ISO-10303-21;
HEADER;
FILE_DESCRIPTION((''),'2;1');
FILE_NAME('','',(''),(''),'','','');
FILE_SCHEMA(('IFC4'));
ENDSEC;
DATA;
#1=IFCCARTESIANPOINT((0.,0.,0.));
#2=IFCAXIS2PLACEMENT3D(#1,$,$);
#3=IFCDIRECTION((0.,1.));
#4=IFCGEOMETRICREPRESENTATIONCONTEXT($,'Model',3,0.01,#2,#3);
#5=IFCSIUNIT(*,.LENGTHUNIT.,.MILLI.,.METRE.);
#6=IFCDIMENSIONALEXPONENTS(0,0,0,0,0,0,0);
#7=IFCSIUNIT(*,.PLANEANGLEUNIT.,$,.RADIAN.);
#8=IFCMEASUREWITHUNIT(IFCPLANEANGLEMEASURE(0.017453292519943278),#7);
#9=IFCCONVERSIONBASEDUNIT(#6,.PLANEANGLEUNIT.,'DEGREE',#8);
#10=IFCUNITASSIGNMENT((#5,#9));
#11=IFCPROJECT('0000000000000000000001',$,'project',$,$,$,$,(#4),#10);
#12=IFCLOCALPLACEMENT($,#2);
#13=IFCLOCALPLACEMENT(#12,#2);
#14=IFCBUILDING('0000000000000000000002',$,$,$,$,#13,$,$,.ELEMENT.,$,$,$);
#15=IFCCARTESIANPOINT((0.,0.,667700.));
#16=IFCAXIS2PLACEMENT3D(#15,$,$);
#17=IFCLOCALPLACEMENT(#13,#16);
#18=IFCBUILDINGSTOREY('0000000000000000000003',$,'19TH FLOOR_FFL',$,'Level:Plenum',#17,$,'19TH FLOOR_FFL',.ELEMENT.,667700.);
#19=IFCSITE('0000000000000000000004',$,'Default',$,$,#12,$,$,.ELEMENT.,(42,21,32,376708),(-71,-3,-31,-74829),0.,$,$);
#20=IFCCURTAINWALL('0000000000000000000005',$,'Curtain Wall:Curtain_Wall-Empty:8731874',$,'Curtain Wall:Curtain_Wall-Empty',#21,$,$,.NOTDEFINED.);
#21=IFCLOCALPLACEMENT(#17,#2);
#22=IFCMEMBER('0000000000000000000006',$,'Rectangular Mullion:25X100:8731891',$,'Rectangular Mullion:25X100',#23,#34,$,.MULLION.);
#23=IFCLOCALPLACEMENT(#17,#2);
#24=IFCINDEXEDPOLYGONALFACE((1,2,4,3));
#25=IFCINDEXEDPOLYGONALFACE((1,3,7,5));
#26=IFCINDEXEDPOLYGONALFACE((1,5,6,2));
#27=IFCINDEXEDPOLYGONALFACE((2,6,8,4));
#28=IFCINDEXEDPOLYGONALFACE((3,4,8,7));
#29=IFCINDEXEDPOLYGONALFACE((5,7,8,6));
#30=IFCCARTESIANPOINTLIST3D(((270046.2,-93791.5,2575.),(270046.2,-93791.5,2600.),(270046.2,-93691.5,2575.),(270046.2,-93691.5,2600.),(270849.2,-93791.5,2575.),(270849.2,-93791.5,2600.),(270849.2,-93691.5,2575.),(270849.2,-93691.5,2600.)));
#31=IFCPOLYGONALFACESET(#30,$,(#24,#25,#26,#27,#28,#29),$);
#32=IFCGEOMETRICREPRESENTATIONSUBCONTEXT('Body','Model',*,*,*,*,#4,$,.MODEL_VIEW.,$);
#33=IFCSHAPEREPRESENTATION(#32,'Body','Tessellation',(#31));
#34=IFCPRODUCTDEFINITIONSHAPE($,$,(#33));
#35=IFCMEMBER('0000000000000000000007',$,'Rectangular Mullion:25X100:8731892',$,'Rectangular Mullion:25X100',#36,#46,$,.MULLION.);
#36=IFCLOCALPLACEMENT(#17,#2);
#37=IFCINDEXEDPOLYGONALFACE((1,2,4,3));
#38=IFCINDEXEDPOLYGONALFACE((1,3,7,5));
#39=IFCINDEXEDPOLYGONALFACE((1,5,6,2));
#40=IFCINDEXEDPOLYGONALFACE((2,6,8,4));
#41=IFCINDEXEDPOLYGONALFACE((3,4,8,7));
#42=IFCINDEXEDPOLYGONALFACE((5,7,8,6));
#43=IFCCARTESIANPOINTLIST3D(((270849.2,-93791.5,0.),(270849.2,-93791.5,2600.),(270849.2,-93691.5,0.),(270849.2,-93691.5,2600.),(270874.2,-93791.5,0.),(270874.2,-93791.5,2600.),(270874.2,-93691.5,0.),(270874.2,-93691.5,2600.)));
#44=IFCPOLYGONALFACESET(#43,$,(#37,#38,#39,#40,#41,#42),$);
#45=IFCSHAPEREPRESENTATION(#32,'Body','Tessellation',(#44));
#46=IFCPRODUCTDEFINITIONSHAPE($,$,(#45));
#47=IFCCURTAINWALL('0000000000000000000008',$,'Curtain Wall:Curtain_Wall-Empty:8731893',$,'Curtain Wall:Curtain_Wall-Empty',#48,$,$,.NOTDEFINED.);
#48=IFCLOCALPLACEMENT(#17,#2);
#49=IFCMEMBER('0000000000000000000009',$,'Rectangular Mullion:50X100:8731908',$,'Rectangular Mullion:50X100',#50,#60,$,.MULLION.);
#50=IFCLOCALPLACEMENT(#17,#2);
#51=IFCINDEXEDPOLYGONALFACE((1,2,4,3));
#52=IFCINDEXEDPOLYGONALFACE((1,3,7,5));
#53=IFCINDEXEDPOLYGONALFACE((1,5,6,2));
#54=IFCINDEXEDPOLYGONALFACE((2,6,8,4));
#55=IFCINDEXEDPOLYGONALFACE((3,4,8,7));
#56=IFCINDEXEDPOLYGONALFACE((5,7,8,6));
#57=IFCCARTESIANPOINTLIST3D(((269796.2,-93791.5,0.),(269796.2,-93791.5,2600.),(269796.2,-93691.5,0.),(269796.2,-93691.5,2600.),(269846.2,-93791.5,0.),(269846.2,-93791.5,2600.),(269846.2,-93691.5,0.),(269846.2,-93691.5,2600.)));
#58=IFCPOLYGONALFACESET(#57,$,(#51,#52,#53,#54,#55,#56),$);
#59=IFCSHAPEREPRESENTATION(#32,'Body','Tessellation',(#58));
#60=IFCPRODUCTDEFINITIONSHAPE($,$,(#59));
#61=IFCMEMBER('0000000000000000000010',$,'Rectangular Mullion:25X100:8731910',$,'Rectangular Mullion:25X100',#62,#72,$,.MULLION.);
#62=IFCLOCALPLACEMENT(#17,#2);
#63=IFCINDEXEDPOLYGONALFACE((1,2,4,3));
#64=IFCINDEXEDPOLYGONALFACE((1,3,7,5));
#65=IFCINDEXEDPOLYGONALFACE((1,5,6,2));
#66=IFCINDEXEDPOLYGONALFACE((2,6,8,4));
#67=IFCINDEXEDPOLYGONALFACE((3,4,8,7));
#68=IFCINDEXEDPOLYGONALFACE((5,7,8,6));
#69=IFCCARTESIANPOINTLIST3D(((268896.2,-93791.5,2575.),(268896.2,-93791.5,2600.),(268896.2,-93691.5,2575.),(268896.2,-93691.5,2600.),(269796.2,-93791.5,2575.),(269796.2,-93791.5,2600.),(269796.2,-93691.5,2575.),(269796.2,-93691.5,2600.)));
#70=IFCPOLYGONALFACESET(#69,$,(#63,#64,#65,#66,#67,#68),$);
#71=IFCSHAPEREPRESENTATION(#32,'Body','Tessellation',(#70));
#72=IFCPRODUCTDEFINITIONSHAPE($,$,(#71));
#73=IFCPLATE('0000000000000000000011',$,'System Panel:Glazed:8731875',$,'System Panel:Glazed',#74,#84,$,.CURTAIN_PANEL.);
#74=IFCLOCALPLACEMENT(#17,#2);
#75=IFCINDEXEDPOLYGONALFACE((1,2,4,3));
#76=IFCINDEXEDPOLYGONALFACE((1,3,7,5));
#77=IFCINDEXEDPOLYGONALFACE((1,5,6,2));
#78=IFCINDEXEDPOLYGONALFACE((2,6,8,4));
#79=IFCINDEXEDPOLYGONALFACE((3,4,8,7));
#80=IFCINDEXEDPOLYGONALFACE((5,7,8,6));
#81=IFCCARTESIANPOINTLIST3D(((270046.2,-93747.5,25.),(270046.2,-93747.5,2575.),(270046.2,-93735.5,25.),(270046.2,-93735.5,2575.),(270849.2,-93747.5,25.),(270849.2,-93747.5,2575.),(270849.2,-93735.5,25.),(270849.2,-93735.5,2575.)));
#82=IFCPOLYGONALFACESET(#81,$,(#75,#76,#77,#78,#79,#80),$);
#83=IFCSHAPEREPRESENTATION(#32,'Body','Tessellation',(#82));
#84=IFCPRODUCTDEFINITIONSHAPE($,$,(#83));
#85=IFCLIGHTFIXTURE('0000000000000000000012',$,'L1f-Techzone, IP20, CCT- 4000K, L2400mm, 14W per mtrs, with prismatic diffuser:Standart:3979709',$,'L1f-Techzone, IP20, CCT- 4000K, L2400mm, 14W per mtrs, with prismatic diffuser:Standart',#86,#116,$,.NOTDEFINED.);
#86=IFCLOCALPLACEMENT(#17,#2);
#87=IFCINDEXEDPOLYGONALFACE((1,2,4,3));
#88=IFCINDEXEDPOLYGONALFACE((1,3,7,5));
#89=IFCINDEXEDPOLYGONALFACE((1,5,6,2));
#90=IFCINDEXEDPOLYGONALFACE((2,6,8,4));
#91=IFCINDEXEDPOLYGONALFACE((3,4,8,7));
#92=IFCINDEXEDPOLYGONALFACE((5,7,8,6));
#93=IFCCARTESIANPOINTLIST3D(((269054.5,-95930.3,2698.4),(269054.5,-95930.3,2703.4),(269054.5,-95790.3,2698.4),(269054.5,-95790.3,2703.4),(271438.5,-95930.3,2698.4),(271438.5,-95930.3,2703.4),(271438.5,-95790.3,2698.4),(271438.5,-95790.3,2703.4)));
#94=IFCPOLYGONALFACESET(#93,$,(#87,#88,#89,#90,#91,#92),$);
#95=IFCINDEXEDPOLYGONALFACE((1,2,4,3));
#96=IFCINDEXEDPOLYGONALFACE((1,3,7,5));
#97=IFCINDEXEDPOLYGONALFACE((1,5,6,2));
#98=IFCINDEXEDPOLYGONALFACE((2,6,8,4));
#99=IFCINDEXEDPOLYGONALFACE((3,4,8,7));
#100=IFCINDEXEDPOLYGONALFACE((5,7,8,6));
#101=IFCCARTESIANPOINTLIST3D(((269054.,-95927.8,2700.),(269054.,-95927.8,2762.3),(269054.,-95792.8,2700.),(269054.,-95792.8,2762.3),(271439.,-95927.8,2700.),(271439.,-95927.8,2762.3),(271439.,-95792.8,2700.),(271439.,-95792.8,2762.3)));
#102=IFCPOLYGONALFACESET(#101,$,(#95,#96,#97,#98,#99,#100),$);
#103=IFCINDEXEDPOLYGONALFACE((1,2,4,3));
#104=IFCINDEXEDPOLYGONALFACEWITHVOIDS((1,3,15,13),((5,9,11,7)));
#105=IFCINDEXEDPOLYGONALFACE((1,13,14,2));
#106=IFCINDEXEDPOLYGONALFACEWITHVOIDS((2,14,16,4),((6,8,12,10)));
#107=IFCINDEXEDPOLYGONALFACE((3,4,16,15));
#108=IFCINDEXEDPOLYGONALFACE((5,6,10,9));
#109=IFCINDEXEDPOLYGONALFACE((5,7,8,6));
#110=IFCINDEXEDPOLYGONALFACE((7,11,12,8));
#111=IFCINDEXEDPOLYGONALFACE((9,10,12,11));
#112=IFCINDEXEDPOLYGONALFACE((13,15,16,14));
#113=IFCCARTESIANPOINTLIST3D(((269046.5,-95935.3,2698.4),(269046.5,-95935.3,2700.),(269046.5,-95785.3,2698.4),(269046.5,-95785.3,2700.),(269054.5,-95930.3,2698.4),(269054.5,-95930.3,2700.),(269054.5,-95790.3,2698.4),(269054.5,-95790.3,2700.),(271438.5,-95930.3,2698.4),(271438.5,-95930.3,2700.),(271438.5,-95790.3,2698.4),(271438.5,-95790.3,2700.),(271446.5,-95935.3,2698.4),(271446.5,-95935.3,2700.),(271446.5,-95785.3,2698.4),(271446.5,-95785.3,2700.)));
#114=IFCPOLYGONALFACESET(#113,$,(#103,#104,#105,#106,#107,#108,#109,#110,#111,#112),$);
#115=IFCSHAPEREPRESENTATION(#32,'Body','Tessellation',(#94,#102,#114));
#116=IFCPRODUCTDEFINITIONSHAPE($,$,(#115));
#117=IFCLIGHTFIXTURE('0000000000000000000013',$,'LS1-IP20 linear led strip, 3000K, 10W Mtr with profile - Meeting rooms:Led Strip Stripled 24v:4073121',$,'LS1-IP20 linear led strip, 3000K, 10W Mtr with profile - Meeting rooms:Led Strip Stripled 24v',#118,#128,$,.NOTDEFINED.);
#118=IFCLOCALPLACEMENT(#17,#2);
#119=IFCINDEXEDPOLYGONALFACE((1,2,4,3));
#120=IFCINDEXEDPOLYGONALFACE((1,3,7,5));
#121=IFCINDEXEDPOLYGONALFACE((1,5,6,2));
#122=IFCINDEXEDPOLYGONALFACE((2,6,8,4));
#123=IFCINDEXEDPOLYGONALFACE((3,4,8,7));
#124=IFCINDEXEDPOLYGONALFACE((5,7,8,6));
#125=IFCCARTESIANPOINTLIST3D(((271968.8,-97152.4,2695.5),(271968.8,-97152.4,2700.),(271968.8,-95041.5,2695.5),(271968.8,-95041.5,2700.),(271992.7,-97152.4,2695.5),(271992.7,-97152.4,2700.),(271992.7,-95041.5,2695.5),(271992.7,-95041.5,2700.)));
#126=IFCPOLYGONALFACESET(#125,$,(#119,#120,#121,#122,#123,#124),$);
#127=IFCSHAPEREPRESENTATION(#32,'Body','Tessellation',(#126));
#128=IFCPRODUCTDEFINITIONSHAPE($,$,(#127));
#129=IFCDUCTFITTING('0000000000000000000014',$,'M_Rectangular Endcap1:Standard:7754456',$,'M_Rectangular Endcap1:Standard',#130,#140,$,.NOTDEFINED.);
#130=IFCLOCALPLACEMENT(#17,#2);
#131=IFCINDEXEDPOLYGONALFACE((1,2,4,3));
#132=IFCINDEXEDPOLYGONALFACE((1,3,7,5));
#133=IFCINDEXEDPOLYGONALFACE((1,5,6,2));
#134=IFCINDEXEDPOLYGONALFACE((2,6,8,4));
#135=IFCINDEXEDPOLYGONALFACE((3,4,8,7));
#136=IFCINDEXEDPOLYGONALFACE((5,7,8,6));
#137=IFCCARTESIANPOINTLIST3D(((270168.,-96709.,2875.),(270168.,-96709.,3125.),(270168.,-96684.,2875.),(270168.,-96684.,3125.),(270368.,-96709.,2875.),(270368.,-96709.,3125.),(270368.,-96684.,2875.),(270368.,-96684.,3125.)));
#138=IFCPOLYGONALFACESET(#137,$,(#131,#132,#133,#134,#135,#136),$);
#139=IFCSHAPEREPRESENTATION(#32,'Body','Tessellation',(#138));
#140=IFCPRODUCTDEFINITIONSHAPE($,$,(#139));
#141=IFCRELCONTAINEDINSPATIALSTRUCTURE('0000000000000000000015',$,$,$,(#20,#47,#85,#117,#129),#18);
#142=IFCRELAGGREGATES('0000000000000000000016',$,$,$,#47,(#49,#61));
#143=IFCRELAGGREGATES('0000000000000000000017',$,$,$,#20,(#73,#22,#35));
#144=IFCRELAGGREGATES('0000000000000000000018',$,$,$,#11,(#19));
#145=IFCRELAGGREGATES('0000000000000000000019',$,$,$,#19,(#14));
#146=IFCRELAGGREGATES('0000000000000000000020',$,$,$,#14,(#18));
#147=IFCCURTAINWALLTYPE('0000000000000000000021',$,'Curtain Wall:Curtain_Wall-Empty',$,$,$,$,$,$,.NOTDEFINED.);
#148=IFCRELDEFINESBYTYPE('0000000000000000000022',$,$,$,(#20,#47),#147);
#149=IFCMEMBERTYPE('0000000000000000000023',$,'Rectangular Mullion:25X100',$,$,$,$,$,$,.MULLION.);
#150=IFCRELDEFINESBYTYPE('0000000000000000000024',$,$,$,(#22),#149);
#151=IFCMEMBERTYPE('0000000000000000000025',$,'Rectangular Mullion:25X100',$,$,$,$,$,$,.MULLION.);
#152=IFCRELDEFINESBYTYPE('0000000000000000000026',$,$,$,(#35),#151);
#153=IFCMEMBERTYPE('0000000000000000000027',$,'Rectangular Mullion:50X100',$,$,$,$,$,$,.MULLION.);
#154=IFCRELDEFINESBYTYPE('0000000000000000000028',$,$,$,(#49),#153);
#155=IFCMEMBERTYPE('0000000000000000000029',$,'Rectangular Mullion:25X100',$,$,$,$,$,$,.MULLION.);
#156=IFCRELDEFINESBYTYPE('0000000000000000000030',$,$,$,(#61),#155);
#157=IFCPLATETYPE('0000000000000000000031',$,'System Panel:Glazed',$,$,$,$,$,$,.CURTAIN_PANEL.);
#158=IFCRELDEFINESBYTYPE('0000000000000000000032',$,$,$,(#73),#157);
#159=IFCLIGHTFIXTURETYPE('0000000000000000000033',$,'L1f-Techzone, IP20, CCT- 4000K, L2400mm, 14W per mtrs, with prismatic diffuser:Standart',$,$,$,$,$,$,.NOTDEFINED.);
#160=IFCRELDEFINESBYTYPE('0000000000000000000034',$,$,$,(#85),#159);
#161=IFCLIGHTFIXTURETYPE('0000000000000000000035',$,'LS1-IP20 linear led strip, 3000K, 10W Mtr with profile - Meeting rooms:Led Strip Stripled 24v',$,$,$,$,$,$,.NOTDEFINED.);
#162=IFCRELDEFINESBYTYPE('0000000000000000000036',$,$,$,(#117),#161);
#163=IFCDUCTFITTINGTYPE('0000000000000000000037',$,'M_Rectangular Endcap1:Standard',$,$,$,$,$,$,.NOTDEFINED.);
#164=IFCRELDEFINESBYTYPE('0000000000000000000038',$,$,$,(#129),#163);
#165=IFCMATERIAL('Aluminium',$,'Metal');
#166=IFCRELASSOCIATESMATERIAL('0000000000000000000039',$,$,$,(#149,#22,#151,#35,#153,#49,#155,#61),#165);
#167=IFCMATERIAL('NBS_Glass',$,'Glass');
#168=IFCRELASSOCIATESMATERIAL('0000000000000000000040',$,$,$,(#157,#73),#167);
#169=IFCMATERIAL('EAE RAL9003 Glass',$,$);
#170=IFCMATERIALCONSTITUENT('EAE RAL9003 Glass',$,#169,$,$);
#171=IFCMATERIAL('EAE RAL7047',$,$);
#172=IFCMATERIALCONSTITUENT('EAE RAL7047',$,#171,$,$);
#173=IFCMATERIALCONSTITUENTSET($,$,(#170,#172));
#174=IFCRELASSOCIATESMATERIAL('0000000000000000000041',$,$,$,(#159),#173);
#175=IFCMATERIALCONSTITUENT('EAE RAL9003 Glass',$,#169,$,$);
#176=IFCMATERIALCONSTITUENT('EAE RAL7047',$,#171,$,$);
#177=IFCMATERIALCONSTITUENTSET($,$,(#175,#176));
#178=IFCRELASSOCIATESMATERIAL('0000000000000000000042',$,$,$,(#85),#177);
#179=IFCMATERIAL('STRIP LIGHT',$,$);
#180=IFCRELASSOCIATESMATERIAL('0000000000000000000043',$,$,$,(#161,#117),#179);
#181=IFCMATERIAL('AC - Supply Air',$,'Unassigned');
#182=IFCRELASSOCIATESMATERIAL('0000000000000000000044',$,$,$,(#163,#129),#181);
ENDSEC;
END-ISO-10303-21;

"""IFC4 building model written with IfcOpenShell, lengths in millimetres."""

from ifc_helpers import new_model, entity, si_unit, converted_unit, direction, frame, origin, place, context, subcontext, project, spatial, indexed_curve, outline, extrude, source, transform, mapped, material, constituent, constituent_set, type_object, type_shapes, element, aggregate, save


model = new_model("IFC4")

# Units and contexts
model_context = context("Model", 3, precision=0.01, world=origin(), true_north=direction((0.0, 1.0)))
body_context = subcontext(model_context, "Body", "Model", "MODEL_VIEW")
ifc_project = project(units=[si_unit("LENGTHUNIT", "METRE", prefix="MILLI"), converted_unit("PLANEANGLEUNIT", "DEGREE", entity("IfcPlaneAngleMeasure", 0.017453292519943278), si_unit("PLANEANGLEUNIT", "RADIAN"), dimensions=[0, 0, 0, 0, 0, 0, 0])], contexts=[model_context])

# Site, building, storey
site_placement = place(None, origin())
site = spatial("IfcSite", under=ifc_project, at=site_placement, Name="Default", CompositionType="ELEMENT", RefLatitude=(42, 21, 32, 376708), RefLongitude=(-71, -3, -31, -74829), RefElevation=0.0)
building_placement = place(site_placement, origin())
building = spatial("IfcBuilding", under=site, at=building_placement, CompositionType="ELEMENT")
storey_placement = place(building_placement, frame((0.0, 0.0, 667700.0)))
storey = spatial("IfcBuildingStorey", under=building, at=storey_placement, Name="19TH FLOOR_FFL", ObjectType="Level:Plenum", LongName="19TH FLOOR_FFL", CompositionType="ELEMENT", Elevation=667700.0)

# Curtain walls, members
curtain_wall_type = type_object("IfcCurtainWallType", Name="Curtain Wall:Curtain_Wall-Empty", PredefinedType="NOTDEFINED")
curtain_wall_1_placement = place(storey_placement, frame((0.0, 0.0, -667700.0)))
curtain_wall_1 = element("IfcCurtainWall", 1, at=curtain_wall_1_placement, inside=storey, type_object=curtain_wall_type, Name="Curtain Wall:Curtain_Wall-Empty:8731874", ObjectType="Curtain Wall:Curtain_Wall-Empty", PredefinedType="NOTDEFINED")
ifc_material_1 = material(Name="Aluminium", Category="Metal")
member_type_1 = type_object("IfcMemberType", Name="Rectangular Mullion:25X100", PredefinedType="MULLION", material=ifc_material_1)
shared_shape_1 = source(origin(), body_context, "Body", "SweptSolid", [
    extrude(outline(indexed_curve([(-12.5, -50.0), (12.5, -50.0), (12.5, 50.0), (-12.5, 50.0), (-12.5, -50.0)], self_intersect=False)), frame((-12.5, 0.0, -803.0), z_axis=(0.0, 0.0, 1.0), x_axis=(-1.0, 0.0, 0.0)), (0.0, 0.0, 1.0), 803.0),
])
type_shapes(member_type_1, [shared_shape_1])
member_1_placement = place(curtain_wall_1_placement, frame((270046.2, -93741.5, 670300.0), z_axis=(-1.0, 0.0, 0.0), x_axis=(0.0, 0.0, 1.0)))
member_1 = element("IfcMember", 2, at=member_1_placement, type_object=member_type_1, material=ifc_material_1, Name="Rectangular Mullion:25X100:8731891", ObjectType="Rectangular Mullion:25X100", PredefinedType="MULLION", context=body_context, shape_type="MappedRepresentation", body=[
    mapped(shared_shape_1, transform((0.0, 0.0, 0.0), scale=1.0)),
])
member_type_2 = type_object("IfcMemberType", Name="Rectangular Mullion:25X100", PredefinedType="MULLION", material=ifc_material_1)
shared_shape_2 = source(origin(), body_context, "Body", "SweptSolid", [
    extrude(outline(indexed_curve([(-12.5, -50.0), (12.5, -50.0), (12.5, 50.0), (-12.5, 50.0), (-12.5, -50.0)], self_intersect=False)), frame((-12.5, 0.0, -2600.0), z_axis=(0.0, 0.0, 1.0), x_axis=(-1.0, 0.0, 0.0)), (0.0, 0.0, 1.0), 2600.0),
])
type_shapes(member_type_2, [shared_shape_2])
member_2_placement = place(curtain_wall_1_placement, frame((270874.2, -93741.5, 670300.0)))
member_2 = element("IfcMember", 3, at=member_2_placement, type_object=member_type_2, material=ifc_material_1, Name="Rectangular Mullion:25X100:8731892", ObjectType="Rectangular Mullion:25X100", PredefinedType="MULLION", context=body_context, shape_type="MappedRepresentation", body=[
    mapped(shared_shape_2, transform((0.0, 0.0, 0.0), scale=1.0)),
])
curtain_wall_2_placement = place(storey_placement, frame((0.0, 0.0, -667700.0)))
curtain_wall_2 = element("IfcCurtainWall", 4, at=curtain_wall_2_placement, inside=storey, type_object=curtain_wall_type, Name="Curtain Wall:Curtain_Wall-Empty:8731893", ObjectType="Curtain Wall:Curtain_Wall-Empty", PredefinedType="NOTDEFINED")
member_type_3 = type_object("IfcMemberType", Name="Rectangular Mullion:50X100", PredefinedType="MULLION", material=ifc_material_1)
shared_shape_3 = source(origin(), body_context, "Body", "SweptSolid", [
    extrude(outline(indexed_curve([(-25.0, -50.0), (25.0, -50.0), (25.0, 50.0), (-25.0, 50.0), (-25.0, -50.0)], self_intersect=False)), frame((-25.0, 0.0, -2600.0), z_axis=(0.0, 0.0, 1.0), x_axis=(-1.0, 0.0, 0.0)), (0.0, 0.0, 1.0), 2600.0),
])
type_shapes(member_type_3, [shared_shape_3])
member_3_placement = place(curtain_wall_2_placement, frame((269846.2, -93741.5, 670300.0)))
member_3 = element("IfcMember", 5, at=member_3_placement, type_object=member_type_3, material=ifc_material_1, Name="Rectangular Mullion:50X100:8731908", ObjectType="Rectangular Mullion:50X100", PredefinedType="MULLION", context=body_context, shape_type="MappedRepresentation", body=[
    mapped(shared_shape_3, transform((0.0, 0.0, 0.0), scale=1.0)),
])
member_type_4 = type_object("IfcMemberType", Name="Rectangular Mullion:25X100", PredefinedType="MULLION", material=ifc_material_1)
shared_shape_4 = source(origin(), body_context, "Body", "SweptSolid", [
    extrude(outline(indexed_curve([(-12.5, -50.0), (12.5, -50.0), (12.5, 50.0), (-12.5, 50.0), (-12.5, -50.0)], self_intersect=False)), frame((-12.5, 0.0, -900.0), z_axis=(0.0, 0.0, 1.0), x_axis=(-1.0, 0.0, 0.0)), (0.0, 0.0, 1.0), 900.0),
])
type_shapes(member_type_4, [shared_shape_4])
member_4_placement = place(curtain_wall_2_placement, frame((268896.2, -93741.5, 670300.0), z_axis=(-1.0, 0.0, 0.0), x_axis=(0.0, 0.0, 1.0)))
member_4 = element("IfcMember", 6, at=member_4_placement, type_object=member_type_4, material=ifc_material_1, Name="Rectangular Mullion:25X100:8731910", ObjectType="Rectangular Mullion:25X100", PredefinedType="MULLION", context=body_context, shape_type="MappedRepresentation", body=[
    mapped(shared_shape_4, transform((0.0, 0.0, 0.0), scale=1.0)),
])
aggregate(curtain_wall_2, [member_3, member_4])

# Plate
ifc_material_2 = material(Name="NBS_Glass", Category="Glass")
plate_type = type_object("IfcPlateType", Name="System Panel:Glazed", PredefinedType="CURTAIN_PANEL", material=ifc_material_2)
shared_shape_5 = source(origin(), body_context, "Body", "SweptSolid", [
    extrude(outline(indexed_curve([(-6.0, -401.5), (6.0, -401.5), (6.0, 401.5), (-6.0, 401.5), (-6.0, -401.5)], self_intersect=False)), frame((0.0, 0.0, 0.0), z_axis=(0.0, 0.0, 1.0), x_axis=(0.0, 1.0, 0.0)), (0.0, 0.0, 1.0), 2550.0),
])
type_shapes(plate_type, [shared_shape_5])
plate_placement = place(curtain_wall_1_placement, frame((270447.7, -93741.5, 667725.0), z_axis=(0.0, 0.0, 1.0), x_axis=(-1.0, 0.0, 0.0)))
plate = element("IfcPlate", 7, at=plate_placement, type_object=plate_type, material=ifc_material_2, Name="System Panel:Glazed:8731875", ObjectType="System Panel:Glazed", PredefinedType="CURTAIN_PANEL", context=body_context, shape_type="MappedRepresentation", body=[
    mapped(shared_shape_5, transform((0.0, 0.0, 0.0), scale=1.0)),
])
aggregate(curtain_wall_1, [plate, member_1, member_2])

# Light fixtures
ifc_material_3 = material(Name="EAE RAL9003 Glass")
ifc_constituent_1 = constituent(ifc_material_3, Name="EAE RAL9003 Glass")
ifc_material_4 = material(Name="EAE RAL7047")
ifc_constituent_2 = constituent(ifc_material_4, Name="EAE RAL7047")
ifc_constituent_set_1 = constituent_set(constituents=[ifc_constituent_1, ifc_constituent_2])
ifc_constituent_3 = constituent(ifc_material_3, Name="EAE RAL9003 Glass")
ifc_constituent_4 = constituent(ifc_material_4, Name="EAE RAL7047")
ifc_constituent_set_2 = constituent_set(constituents=[ifc_constituent_3, ifc_constituent_4])
light_fixture_type_1 = type_object("IfcLightFixtureType", Name="L1f-Techzone, IP20, CCT- 4000K, L2400mm, 14W per mtrs, with prismatic diffuser:Standart", PredefinedType="NOTDEFINED", material=ifc_constituent_set_2)
shared_shape_6 = source(origin(), body_context, "Body", "SweptSolid", [
    extrude(outline(indexed_curve([(-70.0, -1192.0), (70.0, -1192.0), (70.0, 1192.0), (-70.0, 1192.0), (-70.0, -1192.0)], self_intersect=False)), frame((0.0, 0.0, -3.4), z_axis=(0.0, 0.0, 1.0), x_axis=(-1.0, 0.0, 0.0)), (0.0, 0.0, 1.0), 5.0),
    extrude(outline(indexed_curve([(-67.5, -1192.5), (67.5, -1192.5), (67.5, 1192.5), (-67.5, 1192.5), (-67.5, -1192.5)], self_intersect=False)), frame((0.0, 0.0, -62.3), z_axis=(0.0, 0.0, 1.0), x_axis=(-1.0, 0.0, 0.0)), (0.0, 0.0, 1.0), 62.3),
    extrude(outline(indexed_curve([(-75.0, -1200.0), (75.0, -1200.0), (75.0, 1200.0), (-75.0, 1200.0), (-75.0, -1200.0)], self_intersect=False), holes=[indexed_curve([(-70.0, -1192.0), (-70.0, 1192.0), (70.0, 1192.0), (70.0, -1192.0), (-70.0, -1192.0)], self_intersect=False)]), frame((0.0, 0.0, 0.0), z_axis=(0.0, 0.0, 1.0), x_axis=(-1.0, 0.0, 0.0)), (0.0, 0.0, 1.0), 1.6),
])
type_shapes(light_fixture_type_1, [shared_shape_6])
light_fixture_1_placement = place(storey_placement, frame((270246.5, -95860.3, 2700.0), z_axis=(0.0, 0.0, -1.0), x_axis=(0.0, 1.0, 0.0)))
element("IfcLightFixture", 8, at=light_fixture_1_placement, inside=storey, type_object=light_fixture_type_1, material=ifc_constituent_set_1, Name="L1f-Techzone, IP20, CCT- 4000K, L2400mm, 14W per mtrs, with prismatic diffuser:Standart:3979709", ObjectType="L1f-Techzone, IP20, CCT- 4000K, L2400mm, 14W per mtrs, with prismatic diffuser:Standart", PredefinedType="NOTDEFINED", context=body_context, shape_type="MappedRepresentation", body=[
    mapped(shared_shape_6, transform((0.0, 0.0, 0.0), scale=1.0)),
])
ifc_material_5 = material(Name="STRIP LIGHT")
light_fixture_type_2 = type_object("IfcLightFixtureType", Name="LS1-IP20 linear led strip, 3000K, 10W Mtr with profile - Meeting rooms:Led Strip Stripled 24v", PredefinedType="NOTDEFINED", material=ifc_material_5)
shared_shape_7 = source(origin(), body_context, "Body", "SweptSolid", [
    extrude(outline(indexed_curve([(-11.9, -1055.5), (11.9, -1055.5), (11.9, 1055.5), (-11.9, 1055.5), (-11.9, -1055.5)], self_intersect=False)), frame((0.0, 0.3, 0.0), z_axis=(0.0, 0.0, 1.0), x_axis=(0.0, -1.0, 0.0)), (0.0, 0.0, 1.0), 4.5),
])
type_shapes(light_fixture_type_2, [shared_shape_7])
light_fixture_2_placement = place(storey_placement, frame((271981.1, -96097.0, 2700.0), z_axis=(0.0, 0.0, -1.0), x_axis=(0.0, -1.0, 0.0)))
element("IfcLightFixture", 9, at=light_fixture_2_placement, inside=storey, type_object=light_fixture_type_2, material=ifc_material_5, Name="LS1-IP20 linear led strip, 3000K, 10W Mtr with profile - Meeting rooms:Led Strip Stripled 24v:4073121", ObjectType="LS1-IP20 linear led strip, 3000K, 10W Mtr with profile - Meeting rooms:Led Strip Stripled 24v", PredefinedType="NOTDEFINED", context=body_context, shape_type="MappedRepresentation", body=[
    mapped(shared_shape_7, transform((0.0, 0.0, 0.0), scale=1.0)),
])

# Duct fitting
ifc_material_6 = material(Name="AC - Supply Air", Category="Unassigned")
duct_fitting_type_1 = type_object("IfcDuctFittingType", Name="M_Rectangular Endcap1:Standard", PredefinedType="NOTDEFINED", material=ifc_material_6)
shared_shape_8 = source(origin(), body_context, "Body", "SweptSolid", [
    extrude(outline(indexed_curve([(-12.5, -100.0), (12.5, -100.0), (12.5, 100.0), (-12.5, 100.0), (-12.5, -100.0)], self_intersect=False)), frame((12.5, 0.0, -125.0)), (0.0, 0.0, 1.0), 250.0),
])
type_shapes(duct_fitting_type_1, [shared_shape_8])
duct_fitting_placement = place(storey_placement, frame((270268.0, -96684.0, 3000.0), z_axis=(0.0, 0.0, 1.0), x_axis=(0.0, -1.0, 0.0)))
element("IfcDuctFitting", 10, at=duct_fitting_placement, inside=storey, type_object=duct_fitting_type_1, material=ifc_material_6, Name="M_Rectangular Endcap1:Standard:7754456", ObjectType="M_Rectangular Endcap1:Standard", PredefinedType="NOTDEFINED", context=body_context, shape_type="MappedRepresentation", body=[
    mapped(shared_shape_8, transform((0.0, 0.0, 0.0), scale=1.0)),
])

save(model, "model.ifc")
